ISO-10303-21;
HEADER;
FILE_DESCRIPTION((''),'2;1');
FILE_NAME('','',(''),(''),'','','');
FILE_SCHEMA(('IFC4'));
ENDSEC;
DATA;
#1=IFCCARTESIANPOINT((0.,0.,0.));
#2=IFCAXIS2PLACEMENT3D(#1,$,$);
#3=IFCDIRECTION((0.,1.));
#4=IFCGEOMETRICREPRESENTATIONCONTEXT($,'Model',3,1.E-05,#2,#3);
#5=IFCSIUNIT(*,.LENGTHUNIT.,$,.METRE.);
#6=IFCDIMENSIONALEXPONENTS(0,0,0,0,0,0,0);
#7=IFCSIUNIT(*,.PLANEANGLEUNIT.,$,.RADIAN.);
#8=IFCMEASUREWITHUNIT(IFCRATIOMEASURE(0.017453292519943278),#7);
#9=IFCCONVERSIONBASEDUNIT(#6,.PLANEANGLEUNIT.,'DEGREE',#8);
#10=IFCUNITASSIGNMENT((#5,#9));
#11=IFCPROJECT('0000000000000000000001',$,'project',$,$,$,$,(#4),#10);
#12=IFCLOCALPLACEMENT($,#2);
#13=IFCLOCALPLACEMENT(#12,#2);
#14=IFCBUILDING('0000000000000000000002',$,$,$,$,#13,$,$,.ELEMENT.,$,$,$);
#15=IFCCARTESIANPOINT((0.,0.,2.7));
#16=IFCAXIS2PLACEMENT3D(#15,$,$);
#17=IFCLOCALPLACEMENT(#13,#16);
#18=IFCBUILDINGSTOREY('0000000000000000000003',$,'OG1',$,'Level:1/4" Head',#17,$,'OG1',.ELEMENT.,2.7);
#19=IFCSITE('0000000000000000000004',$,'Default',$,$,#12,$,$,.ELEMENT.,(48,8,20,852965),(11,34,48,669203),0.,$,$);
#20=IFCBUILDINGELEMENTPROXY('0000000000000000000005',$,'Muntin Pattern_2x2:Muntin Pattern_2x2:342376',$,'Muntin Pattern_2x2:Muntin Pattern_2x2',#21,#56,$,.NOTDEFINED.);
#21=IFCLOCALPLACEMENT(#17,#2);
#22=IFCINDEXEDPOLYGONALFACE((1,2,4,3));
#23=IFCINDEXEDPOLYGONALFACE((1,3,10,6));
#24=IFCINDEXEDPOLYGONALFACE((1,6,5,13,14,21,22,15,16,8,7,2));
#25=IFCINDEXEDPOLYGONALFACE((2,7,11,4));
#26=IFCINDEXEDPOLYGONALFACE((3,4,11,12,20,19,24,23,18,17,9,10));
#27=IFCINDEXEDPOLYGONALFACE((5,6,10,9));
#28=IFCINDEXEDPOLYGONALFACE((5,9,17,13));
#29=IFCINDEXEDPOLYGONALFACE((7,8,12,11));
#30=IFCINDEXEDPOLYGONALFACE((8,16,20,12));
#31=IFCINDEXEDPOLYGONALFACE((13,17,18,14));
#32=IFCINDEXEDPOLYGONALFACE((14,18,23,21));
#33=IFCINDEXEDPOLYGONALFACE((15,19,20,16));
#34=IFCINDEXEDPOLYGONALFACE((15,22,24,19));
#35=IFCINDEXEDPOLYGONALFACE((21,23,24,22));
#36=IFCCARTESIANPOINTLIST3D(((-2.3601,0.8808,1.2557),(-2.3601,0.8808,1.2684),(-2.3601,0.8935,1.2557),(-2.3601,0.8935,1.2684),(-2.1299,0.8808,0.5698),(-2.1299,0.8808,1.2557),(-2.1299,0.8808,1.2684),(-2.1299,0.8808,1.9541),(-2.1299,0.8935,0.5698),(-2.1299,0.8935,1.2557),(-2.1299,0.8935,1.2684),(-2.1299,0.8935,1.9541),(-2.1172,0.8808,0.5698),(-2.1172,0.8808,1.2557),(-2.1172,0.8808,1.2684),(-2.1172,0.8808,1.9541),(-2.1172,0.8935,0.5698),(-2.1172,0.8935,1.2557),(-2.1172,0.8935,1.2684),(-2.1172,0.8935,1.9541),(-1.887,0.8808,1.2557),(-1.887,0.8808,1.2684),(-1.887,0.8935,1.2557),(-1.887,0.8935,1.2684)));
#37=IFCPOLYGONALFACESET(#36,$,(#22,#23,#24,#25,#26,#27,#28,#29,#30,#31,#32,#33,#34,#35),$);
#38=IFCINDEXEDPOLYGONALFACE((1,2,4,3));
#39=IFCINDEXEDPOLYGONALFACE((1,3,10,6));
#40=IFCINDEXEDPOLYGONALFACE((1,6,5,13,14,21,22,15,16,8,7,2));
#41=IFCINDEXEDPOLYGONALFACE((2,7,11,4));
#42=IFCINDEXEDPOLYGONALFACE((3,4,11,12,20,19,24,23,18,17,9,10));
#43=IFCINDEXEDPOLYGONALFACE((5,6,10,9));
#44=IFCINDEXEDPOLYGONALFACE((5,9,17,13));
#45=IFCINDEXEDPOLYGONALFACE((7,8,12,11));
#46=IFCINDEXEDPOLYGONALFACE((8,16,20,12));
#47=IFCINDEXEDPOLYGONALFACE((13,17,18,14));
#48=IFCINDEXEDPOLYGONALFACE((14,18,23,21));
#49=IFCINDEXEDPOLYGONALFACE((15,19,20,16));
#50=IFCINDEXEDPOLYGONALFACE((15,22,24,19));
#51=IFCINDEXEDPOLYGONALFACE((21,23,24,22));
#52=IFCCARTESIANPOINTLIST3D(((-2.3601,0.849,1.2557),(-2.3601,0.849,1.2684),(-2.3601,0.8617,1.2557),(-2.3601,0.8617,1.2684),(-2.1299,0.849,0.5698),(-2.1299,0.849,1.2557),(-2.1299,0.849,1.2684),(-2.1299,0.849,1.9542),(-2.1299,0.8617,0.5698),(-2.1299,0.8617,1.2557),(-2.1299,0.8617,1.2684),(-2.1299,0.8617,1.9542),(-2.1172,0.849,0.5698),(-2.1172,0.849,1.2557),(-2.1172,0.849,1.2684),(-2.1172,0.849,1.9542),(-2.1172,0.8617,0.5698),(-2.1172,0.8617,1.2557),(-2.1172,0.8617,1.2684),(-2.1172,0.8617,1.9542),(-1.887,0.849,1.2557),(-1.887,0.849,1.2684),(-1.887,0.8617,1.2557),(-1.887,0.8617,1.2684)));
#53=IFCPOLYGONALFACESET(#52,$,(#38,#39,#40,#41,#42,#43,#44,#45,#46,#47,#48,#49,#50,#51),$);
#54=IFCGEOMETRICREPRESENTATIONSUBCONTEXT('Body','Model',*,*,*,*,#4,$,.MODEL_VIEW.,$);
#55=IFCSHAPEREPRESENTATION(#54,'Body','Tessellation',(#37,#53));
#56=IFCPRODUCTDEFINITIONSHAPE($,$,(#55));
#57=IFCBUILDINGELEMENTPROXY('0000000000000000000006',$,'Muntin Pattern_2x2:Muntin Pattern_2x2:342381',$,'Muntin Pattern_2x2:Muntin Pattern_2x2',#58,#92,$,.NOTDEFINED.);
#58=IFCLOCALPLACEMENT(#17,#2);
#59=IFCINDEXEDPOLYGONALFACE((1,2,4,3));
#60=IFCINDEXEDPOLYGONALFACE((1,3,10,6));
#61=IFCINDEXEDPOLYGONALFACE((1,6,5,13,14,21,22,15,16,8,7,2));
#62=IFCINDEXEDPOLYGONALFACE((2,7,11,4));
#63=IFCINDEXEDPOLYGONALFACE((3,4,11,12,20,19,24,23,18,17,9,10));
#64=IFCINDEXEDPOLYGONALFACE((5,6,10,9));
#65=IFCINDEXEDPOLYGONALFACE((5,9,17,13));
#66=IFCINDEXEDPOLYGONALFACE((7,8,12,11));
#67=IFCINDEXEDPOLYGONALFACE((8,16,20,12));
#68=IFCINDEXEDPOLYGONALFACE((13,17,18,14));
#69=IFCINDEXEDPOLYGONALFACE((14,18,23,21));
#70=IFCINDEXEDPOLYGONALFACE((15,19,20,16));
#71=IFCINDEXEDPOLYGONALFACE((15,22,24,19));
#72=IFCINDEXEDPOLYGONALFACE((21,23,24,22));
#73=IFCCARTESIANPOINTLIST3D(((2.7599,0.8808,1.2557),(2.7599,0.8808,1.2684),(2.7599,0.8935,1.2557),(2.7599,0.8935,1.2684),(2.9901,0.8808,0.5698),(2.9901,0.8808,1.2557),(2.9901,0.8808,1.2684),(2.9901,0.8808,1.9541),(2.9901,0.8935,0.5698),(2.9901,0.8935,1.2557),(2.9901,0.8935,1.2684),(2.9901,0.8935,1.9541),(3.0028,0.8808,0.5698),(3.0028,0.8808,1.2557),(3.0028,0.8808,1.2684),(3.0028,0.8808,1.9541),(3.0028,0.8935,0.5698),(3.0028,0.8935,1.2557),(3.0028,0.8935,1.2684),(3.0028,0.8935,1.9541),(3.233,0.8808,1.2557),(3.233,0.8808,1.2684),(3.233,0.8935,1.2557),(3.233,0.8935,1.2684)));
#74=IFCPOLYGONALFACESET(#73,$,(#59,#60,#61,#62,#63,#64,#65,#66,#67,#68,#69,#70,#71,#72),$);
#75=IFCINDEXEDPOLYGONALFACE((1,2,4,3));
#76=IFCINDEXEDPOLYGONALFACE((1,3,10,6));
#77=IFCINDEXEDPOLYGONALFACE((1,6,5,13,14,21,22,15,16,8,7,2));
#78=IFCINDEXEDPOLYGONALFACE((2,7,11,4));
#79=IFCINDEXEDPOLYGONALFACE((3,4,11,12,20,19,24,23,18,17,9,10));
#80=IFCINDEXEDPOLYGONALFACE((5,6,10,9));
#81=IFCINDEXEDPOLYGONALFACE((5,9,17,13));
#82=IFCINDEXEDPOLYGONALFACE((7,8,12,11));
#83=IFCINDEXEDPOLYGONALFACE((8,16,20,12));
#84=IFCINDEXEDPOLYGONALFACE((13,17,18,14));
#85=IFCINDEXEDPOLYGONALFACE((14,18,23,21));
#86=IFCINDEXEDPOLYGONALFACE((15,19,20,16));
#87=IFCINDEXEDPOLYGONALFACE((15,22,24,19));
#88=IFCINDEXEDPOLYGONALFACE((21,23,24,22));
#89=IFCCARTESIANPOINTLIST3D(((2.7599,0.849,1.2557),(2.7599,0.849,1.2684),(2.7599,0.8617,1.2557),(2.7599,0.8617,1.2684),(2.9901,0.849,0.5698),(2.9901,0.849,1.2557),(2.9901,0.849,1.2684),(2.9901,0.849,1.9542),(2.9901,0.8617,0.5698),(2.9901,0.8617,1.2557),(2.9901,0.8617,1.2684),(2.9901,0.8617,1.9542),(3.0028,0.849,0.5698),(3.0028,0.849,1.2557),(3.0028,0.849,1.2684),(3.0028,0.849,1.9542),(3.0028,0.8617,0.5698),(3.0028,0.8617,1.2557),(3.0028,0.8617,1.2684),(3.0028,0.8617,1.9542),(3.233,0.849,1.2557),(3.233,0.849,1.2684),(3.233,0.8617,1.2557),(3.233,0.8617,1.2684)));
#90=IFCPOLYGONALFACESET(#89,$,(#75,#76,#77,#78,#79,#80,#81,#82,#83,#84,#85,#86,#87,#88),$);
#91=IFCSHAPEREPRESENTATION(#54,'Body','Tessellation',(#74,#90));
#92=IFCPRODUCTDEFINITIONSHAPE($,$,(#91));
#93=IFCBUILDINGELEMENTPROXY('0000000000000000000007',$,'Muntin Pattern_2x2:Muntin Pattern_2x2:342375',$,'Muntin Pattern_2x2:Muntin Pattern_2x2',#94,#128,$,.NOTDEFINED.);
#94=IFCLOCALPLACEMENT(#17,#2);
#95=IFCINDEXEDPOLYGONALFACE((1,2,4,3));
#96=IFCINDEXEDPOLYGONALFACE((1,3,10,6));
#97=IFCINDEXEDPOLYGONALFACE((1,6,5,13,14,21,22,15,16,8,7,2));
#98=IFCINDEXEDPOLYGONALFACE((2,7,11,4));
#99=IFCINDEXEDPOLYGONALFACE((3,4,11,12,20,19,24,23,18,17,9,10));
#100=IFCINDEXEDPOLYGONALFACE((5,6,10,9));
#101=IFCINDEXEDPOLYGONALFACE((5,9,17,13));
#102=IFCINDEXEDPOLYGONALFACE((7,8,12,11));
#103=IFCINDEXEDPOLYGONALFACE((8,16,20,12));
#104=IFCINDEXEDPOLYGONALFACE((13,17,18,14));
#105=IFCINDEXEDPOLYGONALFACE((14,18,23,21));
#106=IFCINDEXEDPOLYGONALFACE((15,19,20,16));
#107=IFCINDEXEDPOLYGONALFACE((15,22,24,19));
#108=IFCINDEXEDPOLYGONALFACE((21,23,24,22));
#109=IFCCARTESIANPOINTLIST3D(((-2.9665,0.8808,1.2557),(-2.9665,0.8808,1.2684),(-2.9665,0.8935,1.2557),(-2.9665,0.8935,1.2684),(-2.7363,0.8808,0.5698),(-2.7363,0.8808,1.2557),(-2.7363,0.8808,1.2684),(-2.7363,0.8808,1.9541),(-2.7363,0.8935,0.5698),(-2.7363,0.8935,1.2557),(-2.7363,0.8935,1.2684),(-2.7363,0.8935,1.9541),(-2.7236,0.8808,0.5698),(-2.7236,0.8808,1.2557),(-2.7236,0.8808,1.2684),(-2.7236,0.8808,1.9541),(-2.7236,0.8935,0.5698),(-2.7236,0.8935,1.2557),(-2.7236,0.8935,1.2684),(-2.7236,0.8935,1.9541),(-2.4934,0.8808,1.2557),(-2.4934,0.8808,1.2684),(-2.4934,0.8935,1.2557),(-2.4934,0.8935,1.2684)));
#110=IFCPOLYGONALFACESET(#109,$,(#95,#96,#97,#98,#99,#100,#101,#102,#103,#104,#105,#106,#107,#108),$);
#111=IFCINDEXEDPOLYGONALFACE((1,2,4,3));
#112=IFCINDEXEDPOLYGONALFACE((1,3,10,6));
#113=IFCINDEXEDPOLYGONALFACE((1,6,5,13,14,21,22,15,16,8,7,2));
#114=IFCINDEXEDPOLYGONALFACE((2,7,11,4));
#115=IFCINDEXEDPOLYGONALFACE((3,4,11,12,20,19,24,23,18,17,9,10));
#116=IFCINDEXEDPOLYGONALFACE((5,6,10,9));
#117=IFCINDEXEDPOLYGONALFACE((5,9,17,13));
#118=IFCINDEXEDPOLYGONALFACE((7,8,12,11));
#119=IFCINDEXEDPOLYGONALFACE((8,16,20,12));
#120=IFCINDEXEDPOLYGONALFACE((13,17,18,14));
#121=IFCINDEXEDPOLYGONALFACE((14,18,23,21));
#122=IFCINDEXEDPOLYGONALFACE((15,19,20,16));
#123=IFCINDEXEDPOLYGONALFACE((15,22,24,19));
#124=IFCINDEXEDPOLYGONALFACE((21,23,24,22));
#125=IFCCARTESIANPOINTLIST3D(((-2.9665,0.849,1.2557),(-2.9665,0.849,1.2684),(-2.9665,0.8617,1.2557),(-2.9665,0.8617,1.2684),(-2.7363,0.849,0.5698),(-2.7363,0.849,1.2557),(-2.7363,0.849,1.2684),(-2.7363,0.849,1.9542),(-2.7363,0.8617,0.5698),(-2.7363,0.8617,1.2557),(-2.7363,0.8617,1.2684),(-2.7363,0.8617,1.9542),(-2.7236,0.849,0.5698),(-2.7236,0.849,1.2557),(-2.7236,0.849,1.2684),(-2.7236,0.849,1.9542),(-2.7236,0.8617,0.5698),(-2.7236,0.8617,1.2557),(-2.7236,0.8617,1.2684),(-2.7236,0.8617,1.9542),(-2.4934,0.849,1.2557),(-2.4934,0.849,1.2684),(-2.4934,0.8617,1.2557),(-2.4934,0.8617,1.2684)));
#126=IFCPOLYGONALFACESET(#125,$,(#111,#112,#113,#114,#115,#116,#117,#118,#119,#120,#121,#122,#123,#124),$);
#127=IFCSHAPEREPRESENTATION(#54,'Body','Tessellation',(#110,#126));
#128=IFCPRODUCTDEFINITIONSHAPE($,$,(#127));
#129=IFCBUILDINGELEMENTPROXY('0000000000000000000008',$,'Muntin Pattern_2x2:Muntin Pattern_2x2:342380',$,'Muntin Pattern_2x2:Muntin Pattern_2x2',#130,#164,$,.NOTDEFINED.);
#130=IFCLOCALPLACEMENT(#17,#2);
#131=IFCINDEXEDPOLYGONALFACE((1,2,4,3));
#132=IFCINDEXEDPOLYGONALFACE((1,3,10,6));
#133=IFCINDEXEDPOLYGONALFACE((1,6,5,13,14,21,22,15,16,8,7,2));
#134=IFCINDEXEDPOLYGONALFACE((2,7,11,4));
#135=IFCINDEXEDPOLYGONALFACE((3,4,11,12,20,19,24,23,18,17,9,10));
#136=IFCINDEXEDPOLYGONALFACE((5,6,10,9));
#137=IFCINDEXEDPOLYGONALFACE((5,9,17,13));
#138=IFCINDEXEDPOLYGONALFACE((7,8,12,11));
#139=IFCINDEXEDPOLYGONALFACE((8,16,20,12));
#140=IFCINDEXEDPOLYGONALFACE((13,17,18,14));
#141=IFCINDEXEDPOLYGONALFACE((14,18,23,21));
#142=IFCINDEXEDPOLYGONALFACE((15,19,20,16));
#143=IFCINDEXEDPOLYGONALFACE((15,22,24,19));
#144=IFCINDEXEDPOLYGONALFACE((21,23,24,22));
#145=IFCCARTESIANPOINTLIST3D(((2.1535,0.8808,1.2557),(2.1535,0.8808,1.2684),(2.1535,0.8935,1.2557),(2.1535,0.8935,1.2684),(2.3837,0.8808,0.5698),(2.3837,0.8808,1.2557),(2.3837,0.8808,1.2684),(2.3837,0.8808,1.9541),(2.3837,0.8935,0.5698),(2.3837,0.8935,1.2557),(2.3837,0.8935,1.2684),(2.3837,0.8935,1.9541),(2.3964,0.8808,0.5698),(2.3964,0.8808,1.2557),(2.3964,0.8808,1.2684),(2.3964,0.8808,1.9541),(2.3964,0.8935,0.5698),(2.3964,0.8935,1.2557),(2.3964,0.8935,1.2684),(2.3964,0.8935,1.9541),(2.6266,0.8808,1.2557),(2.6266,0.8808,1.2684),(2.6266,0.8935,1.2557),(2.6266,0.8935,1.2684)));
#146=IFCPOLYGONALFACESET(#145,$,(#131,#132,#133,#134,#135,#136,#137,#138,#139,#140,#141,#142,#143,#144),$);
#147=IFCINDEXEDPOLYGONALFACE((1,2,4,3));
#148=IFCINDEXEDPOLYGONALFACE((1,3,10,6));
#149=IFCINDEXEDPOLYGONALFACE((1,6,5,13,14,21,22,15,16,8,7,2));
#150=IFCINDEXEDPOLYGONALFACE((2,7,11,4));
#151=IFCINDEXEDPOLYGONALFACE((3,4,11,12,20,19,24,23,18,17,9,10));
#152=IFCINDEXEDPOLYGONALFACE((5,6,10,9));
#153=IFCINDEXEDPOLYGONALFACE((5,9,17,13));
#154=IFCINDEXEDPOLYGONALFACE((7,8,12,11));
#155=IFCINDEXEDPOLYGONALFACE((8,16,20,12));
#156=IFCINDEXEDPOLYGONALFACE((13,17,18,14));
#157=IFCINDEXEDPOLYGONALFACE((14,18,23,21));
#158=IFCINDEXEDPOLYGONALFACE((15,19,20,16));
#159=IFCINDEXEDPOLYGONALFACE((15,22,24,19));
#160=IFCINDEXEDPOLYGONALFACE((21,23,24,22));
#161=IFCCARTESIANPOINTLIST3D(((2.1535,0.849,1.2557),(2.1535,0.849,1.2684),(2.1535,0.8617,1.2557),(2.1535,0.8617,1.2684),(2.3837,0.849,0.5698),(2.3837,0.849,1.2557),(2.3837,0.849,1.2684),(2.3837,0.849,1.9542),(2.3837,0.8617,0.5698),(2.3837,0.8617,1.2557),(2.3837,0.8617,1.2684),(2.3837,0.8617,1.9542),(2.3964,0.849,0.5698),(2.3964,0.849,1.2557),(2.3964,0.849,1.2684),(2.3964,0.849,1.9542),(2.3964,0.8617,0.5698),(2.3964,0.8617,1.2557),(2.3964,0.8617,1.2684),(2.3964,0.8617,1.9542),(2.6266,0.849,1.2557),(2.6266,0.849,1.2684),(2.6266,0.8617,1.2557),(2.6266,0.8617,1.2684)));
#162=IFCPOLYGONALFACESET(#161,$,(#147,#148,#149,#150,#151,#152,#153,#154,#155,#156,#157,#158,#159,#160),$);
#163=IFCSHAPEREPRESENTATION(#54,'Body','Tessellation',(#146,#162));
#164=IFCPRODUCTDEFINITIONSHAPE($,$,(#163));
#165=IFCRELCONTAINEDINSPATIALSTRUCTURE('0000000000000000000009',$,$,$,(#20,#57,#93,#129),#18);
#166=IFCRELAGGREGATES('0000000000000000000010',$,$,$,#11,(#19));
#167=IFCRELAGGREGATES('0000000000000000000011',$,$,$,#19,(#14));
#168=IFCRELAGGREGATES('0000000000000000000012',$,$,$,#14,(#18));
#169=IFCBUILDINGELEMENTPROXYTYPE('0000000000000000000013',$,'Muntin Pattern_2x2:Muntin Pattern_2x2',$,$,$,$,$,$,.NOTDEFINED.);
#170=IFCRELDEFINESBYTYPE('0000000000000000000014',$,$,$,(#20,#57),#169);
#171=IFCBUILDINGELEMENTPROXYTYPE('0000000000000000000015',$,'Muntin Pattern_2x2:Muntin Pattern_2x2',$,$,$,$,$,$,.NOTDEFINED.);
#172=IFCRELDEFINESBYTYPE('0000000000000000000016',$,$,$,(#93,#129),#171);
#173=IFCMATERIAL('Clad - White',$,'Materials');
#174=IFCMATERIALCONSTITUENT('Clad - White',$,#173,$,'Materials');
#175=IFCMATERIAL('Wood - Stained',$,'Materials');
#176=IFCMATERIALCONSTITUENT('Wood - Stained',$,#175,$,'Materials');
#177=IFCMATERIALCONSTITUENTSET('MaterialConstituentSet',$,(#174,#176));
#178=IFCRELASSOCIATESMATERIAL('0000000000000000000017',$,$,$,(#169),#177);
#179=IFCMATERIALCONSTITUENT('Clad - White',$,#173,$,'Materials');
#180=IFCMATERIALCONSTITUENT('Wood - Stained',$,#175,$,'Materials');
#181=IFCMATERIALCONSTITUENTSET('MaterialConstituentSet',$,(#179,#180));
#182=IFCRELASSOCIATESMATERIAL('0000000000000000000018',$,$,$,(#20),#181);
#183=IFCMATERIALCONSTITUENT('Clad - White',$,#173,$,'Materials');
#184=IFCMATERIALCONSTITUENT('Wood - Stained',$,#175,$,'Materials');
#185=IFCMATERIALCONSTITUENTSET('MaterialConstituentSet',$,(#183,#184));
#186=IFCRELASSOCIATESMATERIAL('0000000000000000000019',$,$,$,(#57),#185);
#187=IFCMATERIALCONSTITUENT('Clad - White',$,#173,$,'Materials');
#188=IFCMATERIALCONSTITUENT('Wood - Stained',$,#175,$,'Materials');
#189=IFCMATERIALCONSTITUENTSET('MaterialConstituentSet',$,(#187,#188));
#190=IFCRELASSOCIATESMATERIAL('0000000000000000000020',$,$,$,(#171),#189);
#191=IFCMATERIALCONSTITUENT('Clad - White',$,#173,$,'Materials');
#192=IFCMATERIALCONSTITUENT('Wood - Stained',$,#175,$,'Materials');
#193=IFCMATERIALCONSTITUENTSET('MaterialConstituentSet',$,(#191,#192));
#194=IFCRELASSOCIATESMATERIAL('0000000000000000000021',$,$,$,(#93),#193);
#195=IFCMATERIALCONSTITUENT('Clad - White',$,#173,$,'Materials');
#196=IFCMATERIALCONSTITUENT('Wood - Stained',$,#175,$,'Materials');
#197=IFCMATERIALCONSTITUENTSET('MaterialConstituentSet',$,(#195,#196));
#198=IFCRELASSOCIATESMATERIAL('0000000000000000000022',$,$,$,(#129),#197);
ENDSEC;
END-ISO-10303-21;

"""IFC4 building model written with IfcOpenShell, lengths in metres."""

from ifc_helpers import new_model, entity, si_unit, converted_unit, direction, frame, origin, place, context, subcontext, project, spatial, indexed_curve, outline, extrude, source, transform, mapped, material, constituent, constituent_set, type_object, type_shapes, element, save


model = new_model("IFC4")

# Units and contexts
model_context = context("Model", 3, precision=1e-05, world=origin(), true_north=direction((0.0, 1.0)))
body_context = subcontext(model_context, "Body", "Model", "MODEL_VIEW")
ifc_project = project(units=[si_unit("LENGTHUNIT", "METRE"), converted_unit("PLANEANGLEUNIT", "DEGREE", entity("IfcRatioMeasure", 0.017453292519943278), si_unit("PLANEANGLEUNIT", "RADIAN"), dimensions=[0, 0, 0, 0, 0, 0, 0])], contexts=[model_context])

# Site, building, storey
site_placement = place(None, origin())
site = spatial("IfcSite", under=ifc_project, at=site_placement, Name="Default", CompositionType="ELEMENT", RefLatitude=(48, 8, 20, 852965), RefLongitude=(11, 34, 48, 669203), RefElevation=0.0)
building_placement = place(site_placement, origin())
building = spatial("IfcBuilding", under=site, at=building_placement, CompositionType="ELEMENT")
storey_placement = place(building_placement, frame((0.0, 0.0, 2.7)))
storey = spatial("IfcBuildingStorey", under=building, at=storey_placement, Name="OG1", ObjectType="Level:1/4\" Head", LongName="OG1", CompositionType="ELEMENT", Elevation=2.7)

# Building element proxies
ifc_material_1 = material(Name="Clad - White", Category="Materials")
ifc_constituent_1 = constituent(ifc_material_1, Name="Clad - White", Category="Materials")
ifc_material_2 = material(Name="Wood - Stained", Category="Materials")
ifc_constituent_2 = constituent(ifc_material_2, Name="Wood - Stained", Category="Materials")
ifc_constituent_set_1 = constituent_set(constituents=[ifc_constituent_1, ifc_constituent_2], Name="MaterialConstituentSet")
ifc_constituent_3 = constituent(ifc_material_1, Name="Clad - White", Category="Materials")
ifc_constituent_4 = constituent(ifc_material_2, Name="Wood - Stained", Category="Materials")
ifc_constituent_set_2 = constituent_set(constituents=[ifc_constituent_3, ifc_constituent_4], Name="MaterialConstituentSet")
building_element_proxy_type_1 = type_object("IfcBuildingElementProxyType", Name="Muntin Pattern_2x2:Muntin Pattern_2x2", PredefinedType="NOTDEFINED", material=ifc_constituent_set_2)
shared_shape_1 = source(origin(), body_context, "Body", "SweptSolid", [
    extrude(outline(indexed_curve([(0.0064, -0.0064), (0.6921, -0.0064), (0.6921, 0.0063), (0.0064, 0.0063), (0.0064, 0.2365), (-0.0063, 0.2365), (-0.0063, 0.0063), (-0.6922, 0.0063), (-0.6922, -0.0064), (-0.0063, -0.0064), (-0.0063, -0.2365), (0.0064, -0.2365), (0.0064, -0.0064)], self_intersect=False)), frame((0.0, -0.0222, 0.6921), z_axis=(0.0, 1.0, 0.0), x_axis=(0.0, 0.0, 1.0)), (0.0, 0.0, 1.0), 0.0127),
    extrude(outline(indexed_curve([(0.0064, -0.0064), (0.6922, -0.0064), (0.6922, 0.0063), (0.0064, 0.0063), (0.0064, 0.2365), (-0.0063, 0.2365), (-0.0063, 0.0063), (-0.6922, 0.0063), (-0.6922, -0.0064), (-0.0063, -0.0064), (-0.0063, -0.2365), (0.0064, -0.2365), (0.0064, -0.0064)], self_intersect=False)), frame((0.0, 0.0095, 0.6922), z_axis=(0.0, 1.0, 0.0), x_axis=(0.0, 0.0, 1.0)), (0.0, 0.0, 1.0), 0.0127),
])
type_shapes(building_element_proxy_type_1, [shared_shape_1])
proxy_1_placement = place(storey_placement, frame((-2.1235, 0.8713, 0.5699), z_axis=(0.0, 0.0, 1.0), x_axis=(-1.0, 0.0, 0.0)))
element("IfcBuildingElementProxy", 1, at=proxy_1_placement, inside=storey, type_object=building_element_proxy_type_1, material=ifc_constituent_set_1, Name="Muntin Pattern_2x2:Muntin Pattern_2x2:342376", ObjectType="Muntin Pattern_2x2:Muntin Pattern_2x2", PredefinedType="NOTDEFINED", context=body_context, shape_type="MappedRepresentation", body=[
    mapped(shared_shape_1, transform((0.0, 0.0, 0.0), scale=1.0)),
])
ifc_constituent_5 = constituent(ifc_material_1, Name="Clad - White", Category="Materials")
ifc_constituent_6 = constituent(ifc_material_2, Name="Wood - Stained", Category="Materials")
ifc_constituent_set_3 = constituent_set(constituents=[ifc_constituent_5, ifc_constituent_6], Name="MaterialConstituentSet")
proxy_2_placement = place(storey_placement, frame((2.9965, 0.8713, 0.5699), z_axis=(0.0, 0.0, 1.0), x_axis=(-1.0, 0.0, 0.0)))
element("IfcBuildingElementProxy", 2, at=proxy_2_placement, inside=storey, type_object=building_element_proxy_type_1, material=ifc_constituent_set_3, Name="Muntin Pattern_2x2:Muntin Pattern_2x2:342381", ObjectType="Muntin Pattern_2x2:Muntin Pattern_2x2", PredefinedType="NOTDEFINED", context=body_context, shape_type="MappedRepresentation", body=[
    mapped(shared_shape_1, transform((0.0, 0.0, 0.0), scale=1.0)),
])
ifc_constituent_7 = constituent(ifc_material_1, Name="Clad - White", Category="Materials")
ifc_constituent_8 = constituent(ifc_material_2, Name="Wood - Stained", Category="Materials")
ifc_constituent_set_4 = constituent_set(constituents=[ifc_constituent_7, ifc_constituent_8], Name="MaterialConstituentSet")
ifc_constituent_9 = constituent(ifc_material_1, Name="Clad - White", Category="Materials")
ifc_constituent_10 = constituent(ifc_material_2, Name="Wood - Stained", Category="Materials")
ifc_constituent_set_5 = constituent_set(constituents=[ifc_constituent_9, ifc_constituent_10], Name="MaterialConstituentSet")
building_element_proxy_type_2 = type_object("IfcBuildingElementProxyType", Name="Muntin Pattern_2x2:Muntin Pattern_2x2", PredefinedType="NOTDEFINED", material=ifc_constituent_set_5)
shared_shape_2 = source(origin(), body_context, "Body", "SweptSolid", [
    extrude(outline(indexed_curve([(0.0064, -0.0064), (0.6921, -0.0064), (0.6921, 0.0063), (0.0064, 0.0063), (0.0064, 0.2365), (-0.0063, 0.2365), (-0.0063, 0.0063), (-0.6922, 0.0063), (-0.6922, -0.0064), (-0.0063, -0.0064), (-0.0063, -0.2365), (0.0064, -0.2365), (0.0064, -0.0064)], self_intersect=False)), frame((0.0, 0.0095, 0.6921), z_axis=(0.0, 1.0, 0.0), x_axis=(0.0, 0.0, 1.0)), (0.0, 0.0, 1.0), 0.0127),
    extrude(outline(indexed_curve([(0.0064, -0.0064), (0.6922, -0.0064), (0.6922, 0.0063), (0.0064, 0.0063), (0.0064, 0.2365), (-0.0063, 0.2365), (-0.0063, 0.0063), (-0.6922, 0.0063), (-0.6922, -0.0064), (-0.0063, -0.0064), (-0.0063, -0.2365), (0.0064, -0.2365), (0.0064, -0.0064)], self_intersect=False)), frame((0.0, -0.0222, 0.6922), z_axis=(0.0, 1.0, 0.0), x_axis=(0.0, 0.0, 1.0)), (0.0, 0.0, 1.0), 0.0127),
])
type_shapes(building_element_proxy_type_2, [shared_shape_2])
proxy_3_placement = place(storey_placement, frame((-2.73, 0.8713, 0.5699)))
element("IfcBuildingElementProxy", 3, at=proxy_3_placement, inside=storey, type_object=building_element_proxy_type_2, material=ifc_constituent_set_4, Name="Muntin Pattern_2x2:Muntin Pattern_2x2:342375", ObjectType="Muntin Pattern_2x2:Muntin Pattern_2x2", PredefinedType="NOTDEFINED", context=body_context, shape_type="MappedRepresentation", body=[
    mapped(shared_shape_2, transform((0.0, 0.0, 0.0), scale=1.0)),
])
ifc_constituent_11 = constituent(ifc_material_1, Name="Clad - White", Category="Materials")
ifc_constituent_12 = constituent(ifc_material_2, Name="Wood - Stained", Category="Materials")
ifc_constituent_set_6 = constituent_set(constituents=[ifc_constituent_11, ifc_constituent_12], Name="MaterialConstituentSet")
proxy_4_placement = place(storey_placement, frame((2.39, 0.8713, 0.5699)))
element("IfcBuildingElementProxy", 4, at=proxy_4_placement, inside=storey, type_object=building_element_proxy_type_2, material=ifc_constituent_set_6, Name="Muntin Pattern_2x2:Muntin Pattern_2x2:342380", ObjectType="Muntin Pattern_2x2:Muntin Pattern_2x2", PredefinedType="NOTDEFINED", context=body_context, shape_type="MappedRepresentation", body=[
    mapped(shared_shape_2, transform((0.0, 0.0, 0.0), scale=1.0)),
])

save(model, "model.ifc")
